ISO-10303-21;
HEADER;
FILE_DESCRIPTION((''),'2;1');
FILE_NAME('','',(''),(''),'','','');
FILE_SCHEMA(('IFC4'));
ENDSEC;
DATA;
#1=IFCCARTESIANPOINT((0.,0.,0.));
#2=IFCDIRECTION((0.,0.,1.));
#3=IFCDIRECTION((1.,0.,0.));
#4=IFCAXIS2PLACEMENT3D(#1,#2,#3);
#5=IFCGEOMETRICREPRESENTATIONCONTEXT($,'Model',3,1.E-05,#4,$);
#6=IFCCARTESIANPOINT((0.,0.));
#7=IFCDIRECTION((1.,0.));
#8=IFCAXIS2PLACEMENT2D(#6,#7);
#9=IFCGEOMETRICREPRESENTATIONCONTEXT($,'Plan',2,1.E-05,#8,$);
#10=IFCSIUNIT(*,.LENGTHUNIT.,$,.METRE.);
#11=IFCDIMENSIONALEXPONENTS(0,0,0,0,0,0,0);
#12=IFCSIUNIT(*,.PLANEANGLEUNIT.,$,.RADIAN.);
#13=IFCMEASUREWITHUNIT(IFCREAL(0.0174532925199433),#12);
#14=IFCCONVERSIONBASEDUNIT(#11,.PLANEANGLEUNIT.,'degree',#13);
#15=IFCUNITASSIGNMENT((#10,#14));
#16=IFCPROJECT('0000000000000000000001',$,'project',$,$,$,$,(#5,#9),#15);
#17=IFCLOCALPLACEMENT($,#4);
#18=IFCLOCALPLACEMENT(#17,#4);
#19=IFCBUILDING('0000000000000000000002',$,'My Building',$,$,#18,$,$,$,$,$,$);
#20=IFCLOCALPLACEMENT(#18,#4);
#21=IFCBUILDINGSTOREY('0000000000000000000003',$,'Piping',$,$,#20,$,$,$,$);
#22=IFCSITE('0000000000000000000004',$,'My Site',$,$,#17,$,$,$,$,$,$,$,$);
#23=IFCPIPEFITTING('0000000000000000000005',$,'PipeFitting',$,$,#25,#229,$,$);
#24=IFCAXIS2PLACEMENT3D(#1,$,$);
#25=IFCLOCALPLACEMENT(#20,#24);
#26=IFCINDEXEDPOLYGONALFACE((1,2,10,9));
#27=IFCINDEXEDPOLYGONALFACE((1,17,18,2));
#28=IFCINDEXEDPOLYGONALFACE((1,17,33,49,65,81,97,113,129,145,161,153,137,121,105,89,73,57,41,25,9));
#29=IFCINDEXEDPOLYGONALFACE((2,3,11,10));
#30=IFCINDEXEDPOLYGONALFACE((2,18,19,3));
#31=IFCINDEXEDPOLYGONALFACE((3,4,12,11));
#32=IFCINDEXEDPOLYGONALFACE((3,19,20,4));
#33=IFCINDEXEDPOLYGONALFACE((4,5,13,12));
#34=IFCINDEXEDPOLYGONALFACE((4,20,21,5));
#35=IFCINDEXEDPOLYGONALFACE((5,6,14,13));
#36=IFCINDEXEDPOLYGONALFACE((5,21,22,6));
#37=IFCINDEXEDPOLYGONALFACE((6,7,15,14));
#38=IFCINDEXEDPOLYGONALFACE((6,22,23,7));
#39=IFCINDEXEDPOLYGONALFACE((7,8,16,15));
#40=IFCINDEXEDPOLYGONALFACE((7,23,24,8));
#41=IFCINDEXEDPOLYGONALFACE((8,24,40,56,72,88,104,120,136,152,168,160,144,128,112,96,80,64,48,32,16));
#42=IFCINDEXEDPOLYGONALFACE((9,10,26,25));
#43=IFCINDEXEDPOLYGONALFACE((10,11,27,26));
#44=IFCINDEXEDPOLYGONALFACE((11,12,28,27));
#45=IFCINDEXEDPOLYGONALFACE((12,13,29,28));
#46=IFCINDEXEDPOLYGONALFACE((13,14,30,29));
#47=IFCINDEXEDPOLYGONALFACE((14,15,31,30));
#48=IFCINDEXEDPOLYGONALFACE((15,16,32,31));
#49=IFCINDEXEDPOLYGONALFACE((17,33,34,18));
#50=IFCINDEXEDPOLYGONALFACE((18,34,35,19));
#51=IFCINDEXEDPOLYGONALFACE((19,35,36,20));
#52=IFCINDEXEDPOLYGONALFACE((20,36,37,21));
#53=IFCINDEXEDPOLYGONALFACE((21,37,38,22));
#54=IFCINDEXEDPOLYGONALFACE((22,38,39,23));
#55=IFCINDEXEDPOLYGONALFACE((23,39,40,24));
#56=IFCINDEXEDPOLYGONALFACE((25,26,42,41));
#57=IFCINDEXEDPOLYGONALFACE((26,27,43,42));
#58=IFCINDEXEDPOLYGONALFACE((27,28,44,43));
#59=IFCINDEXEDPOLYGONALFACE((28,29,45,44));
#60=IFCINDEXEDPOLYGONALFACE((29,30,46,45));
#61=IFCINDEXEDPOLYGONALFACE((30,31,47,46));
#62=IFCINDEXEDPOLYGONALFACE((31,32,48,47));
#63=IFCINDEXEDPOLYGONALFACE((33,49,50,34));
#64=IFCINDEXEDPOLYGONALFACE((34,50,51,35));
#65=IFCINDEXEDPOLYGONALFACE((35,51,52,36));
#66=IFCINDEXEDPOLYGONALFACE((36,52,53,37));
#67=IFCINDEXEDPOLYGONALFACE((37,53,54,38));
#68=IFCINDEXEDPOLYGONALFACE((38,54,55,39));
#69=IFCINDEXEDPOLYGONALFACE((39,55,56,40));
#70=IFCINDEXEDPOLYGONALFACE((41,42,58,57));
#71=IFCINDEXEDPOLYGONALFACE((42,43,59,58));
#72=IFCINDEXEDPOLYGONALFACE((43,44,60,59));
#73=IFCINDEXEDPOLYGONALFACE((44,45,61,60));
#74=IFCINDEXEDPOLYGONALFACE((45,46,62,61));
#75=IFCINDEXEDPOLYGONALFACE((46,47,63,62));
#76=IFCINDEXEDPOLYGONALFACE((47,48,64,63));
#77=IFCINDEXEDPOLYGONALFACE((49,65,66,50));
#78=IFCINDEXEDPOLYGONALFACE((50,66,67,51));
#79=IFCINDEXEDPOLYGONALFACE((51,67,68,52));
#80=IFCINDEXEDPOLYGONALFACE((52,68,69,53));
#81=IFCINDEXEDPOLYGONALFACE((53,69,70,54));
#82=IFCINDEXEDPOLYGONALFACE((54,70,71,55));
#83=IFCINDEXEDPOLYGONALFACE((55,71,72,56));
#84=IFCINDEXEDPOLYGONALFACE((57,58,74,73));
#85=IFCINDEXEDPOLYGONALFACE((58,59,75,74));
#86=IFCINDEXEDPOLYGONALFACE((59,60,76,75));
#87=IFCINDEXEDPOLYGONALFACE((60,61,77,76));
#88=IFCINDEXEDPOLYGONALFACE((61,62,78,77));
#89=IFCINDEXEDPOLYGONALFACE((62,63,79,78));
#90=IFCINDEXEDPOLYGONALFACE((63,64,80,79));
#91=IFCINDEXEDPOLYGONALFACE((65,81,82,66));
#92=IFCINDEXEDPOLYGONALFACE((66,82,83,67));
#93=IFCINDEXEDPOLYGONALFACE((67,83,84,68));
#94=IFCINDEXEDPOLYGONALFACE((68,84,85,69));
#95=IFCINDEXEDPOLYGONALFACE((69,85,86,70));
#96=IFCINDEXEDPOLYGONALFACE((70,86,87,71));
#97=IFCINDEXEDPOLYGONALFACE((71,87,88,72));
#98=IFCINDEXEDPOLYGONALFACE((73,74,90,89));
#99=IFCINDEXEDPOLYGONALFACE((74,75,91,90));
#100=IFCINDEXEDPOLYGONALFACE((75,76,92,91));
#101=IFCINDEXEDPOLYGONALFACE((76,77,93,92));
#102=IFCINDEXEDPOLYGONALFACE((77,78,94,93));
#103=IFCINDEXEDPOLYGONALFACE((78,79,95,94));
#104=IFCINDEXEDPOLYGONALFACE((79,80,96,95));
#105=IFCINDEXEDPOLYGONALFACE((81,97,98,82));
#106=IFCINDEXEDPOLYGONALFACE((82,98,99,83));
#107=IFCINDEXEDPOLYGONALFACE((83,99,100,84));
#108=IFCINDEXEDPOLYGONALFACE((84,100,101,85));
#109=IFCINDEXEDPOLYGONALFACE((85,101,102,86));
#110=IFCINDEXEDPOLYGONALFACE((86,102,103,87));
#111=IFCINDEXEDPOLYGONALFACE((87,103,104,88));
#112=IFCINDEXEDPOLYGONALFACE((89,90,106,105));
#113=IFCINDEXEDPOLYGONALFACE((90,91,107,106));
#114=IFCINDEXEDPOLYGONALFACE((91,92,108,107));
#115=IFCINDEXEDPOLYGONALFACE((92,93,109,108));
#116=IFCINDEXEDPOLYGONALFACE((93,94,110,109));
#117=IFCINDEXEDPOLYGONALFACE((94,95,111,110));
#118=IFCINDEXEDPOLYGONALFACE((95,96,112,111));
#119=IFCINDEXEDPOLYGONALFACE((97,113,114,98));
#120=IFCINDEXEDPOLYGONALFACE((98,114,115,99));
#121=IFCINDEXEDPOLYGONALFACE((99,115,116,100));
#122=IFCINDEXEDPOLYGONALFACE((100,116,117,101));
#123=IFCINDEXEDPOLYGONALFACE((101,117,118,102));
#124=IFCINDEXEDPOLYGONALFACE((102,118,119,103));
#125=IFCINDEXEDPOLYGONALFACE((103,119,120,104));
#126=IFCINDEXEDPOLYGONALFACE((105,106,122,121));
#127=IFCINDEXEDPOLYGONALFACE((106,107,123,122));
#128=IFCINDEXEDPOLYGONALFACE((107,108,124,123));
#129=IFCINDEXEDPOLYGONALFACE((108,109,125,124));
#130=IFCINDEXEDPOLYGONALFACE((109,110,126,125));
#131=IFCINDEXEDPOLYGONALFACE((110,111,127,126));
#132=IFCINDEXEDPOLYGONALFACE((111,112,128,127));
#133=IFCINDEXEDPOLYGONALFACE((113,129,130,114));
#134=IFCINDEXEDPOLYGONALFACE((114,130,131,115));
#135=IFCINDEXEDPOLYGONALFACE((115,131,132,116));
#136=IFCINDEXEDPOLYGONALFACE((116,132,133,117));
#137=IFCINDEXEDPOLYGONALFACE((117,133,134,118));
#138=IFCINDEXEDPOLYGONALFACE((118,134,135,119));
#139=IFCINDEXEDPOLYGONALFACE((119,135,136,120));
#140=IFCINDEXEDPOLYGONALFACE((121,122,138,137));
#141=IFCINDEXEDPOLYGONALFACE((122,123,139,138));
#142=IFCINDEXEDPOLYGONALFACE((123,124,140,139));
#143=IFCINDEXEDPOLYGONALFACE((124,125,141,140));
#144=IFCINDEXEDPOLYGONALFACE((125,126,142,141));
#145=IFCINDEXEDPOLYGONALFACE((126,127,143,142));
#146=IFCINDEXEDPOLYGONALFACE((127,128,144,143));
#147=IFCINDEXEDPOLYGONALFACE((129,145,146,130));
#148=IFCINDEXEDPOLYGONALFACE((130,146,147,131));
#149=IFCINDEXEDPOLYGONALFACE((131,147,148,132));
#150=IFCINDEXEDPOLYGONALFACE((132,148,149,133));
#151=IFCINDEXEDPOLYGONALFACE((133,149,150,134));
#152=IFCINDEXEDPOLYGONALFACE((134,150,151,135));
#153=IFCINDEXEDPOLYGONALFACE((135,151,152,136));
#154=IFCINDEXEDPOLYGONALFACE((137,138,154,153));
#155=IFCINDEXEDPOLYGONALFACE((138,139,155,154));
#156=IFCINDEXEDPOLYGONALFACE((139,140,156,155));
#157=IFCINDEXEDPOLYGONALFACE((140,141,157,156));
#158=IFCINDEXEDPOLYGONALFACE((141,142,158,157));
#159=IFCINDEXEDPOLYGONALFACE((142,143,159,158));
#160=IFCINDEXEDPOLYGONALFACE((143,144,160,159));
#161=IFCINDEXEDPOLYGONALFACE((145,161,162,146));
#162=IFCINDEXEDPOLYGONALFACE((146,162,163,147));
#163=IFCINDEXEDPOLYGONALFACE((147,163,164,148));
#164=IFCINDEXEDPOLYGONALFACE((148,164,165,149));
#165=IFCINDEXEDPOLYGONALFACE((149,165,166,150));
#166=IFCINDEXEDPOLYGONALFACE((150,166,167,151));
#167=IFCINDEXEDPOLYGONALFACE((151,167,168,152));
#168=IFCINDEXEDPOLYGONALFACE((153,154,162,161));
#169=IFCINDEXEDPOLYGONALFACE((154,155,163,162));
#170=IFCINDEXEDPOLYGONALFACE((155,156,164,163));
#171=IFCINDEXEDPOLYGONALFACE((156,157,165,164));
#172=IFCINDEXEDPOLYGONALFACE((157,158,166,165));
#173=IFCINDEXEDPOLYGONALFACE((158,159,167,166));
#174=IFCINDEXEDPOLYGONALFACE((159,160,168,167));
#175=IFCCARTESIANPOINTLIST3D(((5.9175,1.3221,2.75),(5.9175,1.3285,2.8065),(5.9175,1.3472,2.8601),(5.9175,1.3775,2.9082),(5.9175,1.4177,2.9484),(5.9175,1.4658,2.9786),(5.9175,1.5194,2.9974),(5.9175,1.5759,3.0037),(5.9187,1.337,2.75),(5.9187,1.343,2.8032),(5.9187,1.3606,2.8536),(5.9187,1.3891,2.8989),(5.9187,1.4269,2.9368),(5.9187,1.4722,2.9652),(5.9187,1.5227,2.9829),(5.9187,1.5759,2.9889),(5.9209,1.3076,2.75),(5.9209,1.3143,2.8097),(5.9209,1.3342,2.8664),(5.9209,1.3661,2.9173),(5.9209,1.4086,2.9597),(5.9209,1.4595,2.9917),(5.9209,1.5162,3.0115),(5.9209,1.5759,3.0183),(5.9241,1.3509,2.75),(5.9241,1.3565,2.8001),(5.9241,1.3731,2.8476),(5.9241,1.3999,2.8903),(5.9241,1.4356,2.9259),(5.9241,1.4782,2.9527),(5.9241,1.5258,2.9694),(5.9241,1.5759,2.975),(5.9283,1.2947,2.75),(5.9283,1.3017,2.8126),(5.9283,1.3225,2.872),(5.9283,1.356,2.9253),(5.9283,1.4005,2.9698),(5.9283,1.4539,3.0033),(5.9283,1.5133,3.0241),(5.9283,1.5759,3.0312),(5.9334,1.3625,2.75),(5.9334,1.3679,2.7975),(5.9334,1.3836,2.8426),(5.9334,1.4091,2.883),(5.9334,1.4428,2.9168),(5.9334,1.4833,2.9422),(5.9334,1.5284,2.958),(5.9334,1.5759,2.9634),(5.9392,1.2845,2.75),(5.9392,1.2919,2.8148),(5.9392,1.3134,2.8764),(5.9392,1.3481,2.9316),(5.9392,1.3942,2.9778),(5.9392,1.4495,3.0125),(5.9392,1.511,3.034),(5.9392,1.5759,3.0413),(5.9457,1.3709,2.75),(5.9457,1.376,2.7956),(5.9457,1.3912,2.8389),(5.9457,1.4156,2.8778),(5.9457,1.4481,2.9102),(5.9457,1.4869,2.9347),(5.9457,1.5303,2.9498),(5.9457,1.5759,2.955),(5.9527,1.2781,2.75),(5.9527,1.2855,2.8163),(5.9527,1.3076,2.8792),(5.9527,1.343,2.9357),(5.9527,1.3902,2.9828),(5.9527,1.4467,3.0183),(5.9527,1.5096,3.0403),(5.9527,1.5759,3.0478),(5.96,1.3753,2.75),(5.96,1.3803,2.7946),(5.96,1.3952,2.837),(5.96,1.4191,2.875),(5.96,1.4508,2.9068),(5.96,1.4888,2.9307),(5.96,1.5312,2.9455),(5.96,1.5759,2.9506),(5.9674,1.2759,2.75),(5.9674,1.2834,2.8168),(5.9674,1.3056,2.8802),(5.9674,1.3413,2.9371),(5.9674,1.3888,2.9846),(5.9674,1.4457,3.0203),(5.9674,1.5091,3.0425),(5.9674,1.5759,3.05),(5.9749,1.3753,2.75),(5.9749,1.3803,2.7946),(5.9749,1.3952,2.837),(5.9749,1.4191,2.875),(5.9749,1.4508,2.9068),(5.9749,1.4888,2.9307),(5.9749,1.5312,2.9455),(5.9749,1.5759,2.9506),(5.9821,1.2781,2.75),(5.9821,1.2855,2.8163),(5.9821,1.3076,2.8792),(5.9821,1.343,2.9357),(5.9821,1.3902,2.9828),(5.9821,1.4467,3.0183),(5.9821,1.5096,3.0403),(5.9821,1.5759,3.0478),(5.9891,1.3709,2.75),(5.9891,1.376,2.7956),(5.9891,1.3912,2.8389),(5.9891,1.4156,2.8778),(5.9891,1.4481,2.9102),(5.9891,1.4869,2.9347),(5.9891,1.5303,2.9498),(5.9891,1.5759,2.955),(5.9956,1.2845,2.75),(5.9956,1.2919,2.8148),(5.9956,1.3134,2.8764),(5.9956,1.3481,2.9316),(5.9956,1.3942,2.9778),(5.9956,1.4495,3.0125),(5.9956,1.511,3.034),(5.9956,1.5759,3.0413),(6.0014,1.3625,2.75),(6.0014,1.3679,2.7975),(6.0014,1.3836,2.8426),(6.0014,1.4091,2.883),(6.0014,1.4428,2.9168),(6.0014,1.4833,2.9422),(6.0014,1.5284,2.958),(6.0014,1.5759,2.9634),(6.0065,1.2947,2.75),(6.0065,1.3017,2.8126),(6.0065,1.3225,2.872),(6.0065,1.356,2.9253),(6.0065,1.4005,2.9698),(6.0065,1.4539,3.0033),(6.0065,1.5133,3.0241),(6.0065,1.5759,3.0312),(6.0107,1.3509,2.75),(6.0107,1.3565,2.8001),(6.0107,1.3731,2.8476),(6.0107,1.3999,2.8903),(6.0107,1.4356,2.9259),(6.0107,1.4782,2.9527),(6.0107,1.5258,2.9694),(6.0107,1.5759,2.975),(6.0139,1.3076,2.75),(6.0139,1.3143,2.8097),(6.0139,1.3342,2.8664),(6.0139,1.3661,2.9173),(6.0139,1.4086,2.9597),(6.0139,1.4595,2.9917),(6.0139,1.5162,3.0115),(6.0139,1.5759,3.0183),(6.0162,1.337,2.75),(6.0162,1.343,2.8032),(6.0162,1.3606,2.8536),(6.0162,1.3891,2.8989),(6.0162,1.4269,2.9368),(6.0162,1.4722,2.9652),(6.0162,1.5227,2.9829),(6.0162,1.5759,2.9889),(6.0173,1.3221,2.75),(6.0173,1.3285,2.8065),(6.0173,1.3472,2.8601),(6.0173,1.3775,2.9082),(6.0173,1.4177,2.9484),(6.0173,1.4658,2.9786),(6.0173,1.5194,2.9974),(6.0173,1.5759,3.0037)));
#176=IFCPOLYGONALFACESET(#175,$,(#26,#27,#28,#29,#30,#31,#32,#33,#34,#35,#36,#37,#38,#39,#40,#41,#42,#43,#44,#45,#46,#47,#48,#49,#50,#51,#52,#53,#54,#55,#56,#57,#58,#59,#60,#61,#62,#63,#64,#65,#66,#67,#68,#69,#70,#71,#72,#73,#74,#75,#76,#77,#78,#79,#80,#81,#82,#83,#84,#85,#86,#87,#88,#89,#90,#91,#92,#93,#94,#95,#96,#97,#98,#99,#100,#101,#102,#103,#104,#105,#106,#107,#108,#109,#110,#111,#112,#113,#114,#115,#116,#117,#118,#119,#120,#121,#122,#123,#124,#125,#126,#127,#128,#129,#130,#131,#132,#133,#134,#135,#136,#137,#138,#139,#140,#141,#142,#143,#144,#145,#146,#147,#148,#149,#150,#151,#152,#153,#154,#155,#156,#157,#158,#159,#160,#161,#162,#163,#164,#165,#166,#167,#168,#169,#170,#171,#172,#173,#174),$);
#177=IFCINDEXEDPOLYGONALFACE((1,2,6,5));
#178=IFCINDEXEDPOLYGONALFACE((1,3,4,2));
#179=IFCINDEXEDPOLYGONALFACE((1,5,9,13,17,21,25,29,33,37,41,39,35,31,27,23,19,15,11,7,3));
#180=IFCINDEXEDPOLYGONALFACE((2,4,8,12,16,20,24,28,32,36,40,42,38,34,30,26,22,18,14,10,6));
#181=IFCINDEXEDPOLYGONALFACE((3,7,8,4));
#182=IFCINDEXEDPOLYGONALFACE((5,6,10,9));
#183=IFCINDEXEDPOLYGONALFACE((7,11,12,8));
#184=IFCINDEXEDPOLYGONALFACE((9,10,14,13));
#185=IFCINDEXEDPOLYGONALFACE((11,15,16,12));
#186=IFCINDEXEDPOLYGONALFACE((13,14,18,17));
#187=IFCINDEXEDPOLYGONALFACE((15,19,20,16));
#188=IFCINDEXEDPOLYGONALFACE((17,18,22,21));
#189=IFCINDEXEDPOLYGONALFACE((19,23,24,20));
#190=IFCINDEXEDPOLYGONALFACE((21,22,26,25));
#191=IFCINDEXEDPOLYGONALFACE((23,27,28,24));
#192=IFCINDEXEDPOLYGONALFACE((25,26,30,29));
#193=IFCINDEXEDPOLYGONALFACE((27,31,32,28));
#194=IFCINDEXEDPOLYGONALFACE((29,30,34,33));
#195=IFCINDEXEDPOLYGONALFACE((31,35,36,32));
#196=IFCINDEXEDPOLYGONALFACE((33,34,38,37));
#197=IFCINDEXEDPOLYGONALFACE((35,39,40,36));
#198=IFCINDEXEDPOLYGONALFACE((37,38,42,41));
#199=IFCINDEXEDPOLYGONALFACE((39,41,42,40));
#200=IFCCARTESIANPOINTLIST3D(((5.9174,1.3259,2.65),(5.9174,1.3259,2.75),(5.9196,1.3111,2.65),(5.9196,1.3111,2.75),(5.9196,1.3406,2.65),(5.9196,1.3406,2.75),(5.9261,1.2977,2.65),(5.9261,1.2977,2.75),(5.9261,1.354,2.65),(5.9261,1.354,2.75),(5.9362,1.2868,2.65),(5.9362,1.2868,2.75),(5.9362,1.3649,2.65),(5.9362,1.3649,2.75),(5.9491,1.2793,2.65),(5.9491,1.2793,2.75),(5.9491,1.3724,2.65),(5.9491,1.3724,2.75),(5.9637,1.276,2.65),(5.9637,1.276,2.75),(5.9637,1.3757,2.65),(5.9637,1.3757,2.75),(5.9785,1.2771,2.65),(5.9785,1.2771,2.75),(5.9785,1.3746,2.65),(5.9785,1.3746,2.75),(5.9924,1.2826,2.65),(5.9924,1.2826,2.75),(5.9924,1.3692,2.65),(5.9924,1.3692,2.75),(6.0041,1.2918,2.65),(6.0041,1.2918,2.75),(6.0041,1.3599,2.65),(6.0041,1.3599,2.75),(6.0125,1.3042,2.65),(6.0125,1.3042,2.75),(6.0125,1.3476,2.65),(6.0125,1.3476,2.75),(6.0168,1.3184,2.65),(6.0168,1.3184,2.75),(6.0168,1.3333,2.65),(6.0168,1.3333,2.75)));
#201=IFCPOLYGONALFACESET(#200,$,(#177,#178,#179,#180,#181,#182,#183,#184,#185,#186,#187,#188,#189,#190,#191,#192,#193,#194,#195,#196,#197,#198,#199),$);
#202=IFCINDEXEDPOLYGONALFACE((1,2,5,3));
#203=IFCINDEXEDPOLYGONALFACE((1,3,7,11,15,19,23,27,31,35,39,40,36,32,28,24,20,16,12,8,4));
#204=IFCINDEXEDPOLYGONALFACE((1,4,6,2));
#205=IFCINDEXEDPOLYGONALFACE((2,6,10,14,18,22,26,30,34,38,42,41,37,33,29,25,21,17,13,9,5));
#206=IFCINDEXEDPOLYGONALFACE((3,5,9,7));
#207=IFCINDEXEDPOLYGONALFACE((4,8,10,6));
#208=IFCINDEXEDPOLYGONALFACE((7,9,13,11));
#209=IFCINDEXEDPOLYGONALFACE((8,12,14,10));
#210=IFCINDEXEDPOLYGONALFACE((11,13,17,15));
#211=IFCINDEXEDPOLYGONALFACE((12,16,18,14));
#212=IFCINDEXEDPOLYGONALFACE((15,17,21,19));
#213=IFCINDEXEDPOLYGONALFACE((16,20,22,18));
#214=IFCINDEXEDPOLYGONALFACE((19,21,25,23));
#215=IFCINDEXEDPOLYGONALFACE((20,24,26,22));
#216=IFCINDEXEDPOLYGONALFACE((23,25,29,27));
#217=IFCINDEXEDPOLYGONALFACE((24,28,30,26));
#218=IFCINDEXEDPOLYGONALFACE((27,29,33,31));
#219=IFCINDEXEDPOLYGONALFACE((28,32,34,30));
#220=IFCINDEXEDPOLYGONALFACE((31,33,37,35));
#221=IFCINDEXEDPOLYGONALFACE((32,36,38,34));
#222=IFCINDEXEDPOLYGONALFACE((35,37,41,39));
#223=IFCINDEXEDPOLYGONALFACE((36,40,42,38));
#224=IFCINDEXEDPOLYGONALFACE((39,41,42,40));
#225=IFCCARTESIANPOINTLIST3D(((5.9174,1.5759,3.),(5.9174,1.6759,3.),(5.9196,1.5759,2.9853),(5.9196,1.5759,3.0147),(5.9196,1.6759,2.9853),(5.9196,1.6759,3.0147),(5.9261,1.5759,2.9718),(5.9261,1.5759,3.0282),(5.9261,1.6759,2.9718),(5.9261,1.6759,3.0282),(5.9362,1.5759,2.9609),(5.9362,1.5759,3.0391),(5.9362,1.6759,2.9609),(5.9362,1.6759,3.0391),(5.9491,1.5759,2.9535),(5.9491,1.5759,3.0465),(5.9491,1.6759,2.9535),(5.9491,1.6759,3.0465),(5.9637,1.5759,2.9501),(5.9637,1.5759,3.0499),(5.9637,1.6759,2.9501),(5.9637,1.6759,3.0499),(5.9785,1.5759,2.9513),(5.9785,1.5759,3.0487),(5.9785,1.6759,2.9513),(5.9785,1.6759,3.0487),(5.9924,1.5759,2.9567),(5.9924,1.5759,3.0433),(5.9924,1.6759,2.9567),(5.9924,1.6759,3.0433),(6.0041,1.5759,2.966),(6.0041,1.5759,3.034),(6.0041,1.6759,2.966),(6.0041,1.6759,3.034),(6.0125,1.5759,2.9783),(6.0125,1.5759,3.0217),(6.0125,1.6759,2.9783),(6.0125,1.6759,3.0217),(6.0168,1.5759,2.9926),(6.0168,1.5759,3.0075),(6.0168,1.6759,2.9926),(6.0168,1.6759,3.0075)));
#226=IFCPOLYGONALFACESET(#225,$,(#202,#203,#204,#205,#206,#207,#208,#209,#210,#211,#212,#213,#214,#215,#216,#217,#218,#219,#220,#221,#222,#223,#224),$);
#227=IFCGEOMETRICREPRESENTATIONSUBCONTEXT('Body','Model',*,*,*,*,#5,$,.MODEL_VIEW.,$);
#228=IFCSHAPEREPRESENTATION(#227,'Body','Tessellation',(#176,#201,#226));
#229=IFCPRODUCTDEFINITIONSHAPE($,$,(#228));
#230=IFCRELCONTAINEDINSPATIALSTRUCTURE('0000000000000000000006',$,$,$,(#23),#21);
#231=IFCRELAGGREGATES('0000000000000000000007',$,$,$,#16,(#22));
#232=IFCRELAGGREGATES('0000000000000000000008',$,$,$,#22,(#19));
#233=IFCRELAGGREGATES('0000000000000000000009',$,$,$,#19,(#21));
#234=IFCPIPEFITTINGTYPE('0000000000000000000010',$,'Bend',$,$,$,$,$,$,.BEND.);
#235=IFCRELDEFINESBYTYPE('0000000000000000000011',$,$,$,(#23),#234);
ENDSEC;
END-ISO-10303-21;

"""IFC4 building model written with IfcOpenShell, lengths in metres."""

from ifc_helpers import new_model, entity, si_unit, converted_unit, frame, origin_with_axes, origin_2d_with_axis, place, context, subcontext, project, spatial, circle, extrude, source, transform, mapped, type_object, type_shapes, element, save


model = new_model("IFC4")

# Units and contexts
model_context = context("Model", 3, precision=1e-05, world=origin_with_axes())
plan_context = context("Plan", 2, precision=1e-05, world=origin_2d_with_axis())
body_context = subcontext(model_context, "Body", "Model", "MODEL_VIEW")
ifc_project = project(units=[si_unit("LENGTHUNIT", "METRE"), converted_unit("PLANEANGLEUNIT", "degree", entity("IfcReal", 0.0174532925199433), si_unit("PLANEANGLEUNIT", "RADIAN"), dimensions=[0, 0, 0, 0, 0, 0, 0])], contexts=[model_context, plan_context])

# Site, building, storey
site_placement = place(None, origin_with_axes())
site = spatial("IfcSite", under=ifc_project, at=site_placement, Name="My Site")
building_placement = place(site_placement, origin_with_axes())
building = spatial("IfcBuilding", under=site, at=building_placement, Name="My Building")
storey_placement = place(building_placement, origin_with_axes())
storey = spatial("IfcBuildingStorey", under=building, at=storey_placement, Name="Piping")

# Pipe fitting
pipe_fitting_type = type_object("IfcPipeFittingType", Name="Bend", PredefinedType="BEND")
shared_shape = source(origin_with_axes(), body_context, "Body", "SolidModel", [
    entity("IfcSweptDiskSolid", entity("IfcIndexedPolyCurve", entity("IfcCartesianPointList3D", [[0.0, 0.0, -0.1], [0.0, 0.0732, -0.2768], [0.0, 0.25, -0.35]]), [entity("IfcArcIndex", [1, 2, 3])]), 0.05),
    extrude(circle(Radius=0.05), origin_with_axes(), (0.0, 0.0, -1.0), 0.1),
    extrude(circle(Radius=0.05), frame((0.0, 0.25, -0.35), z_axis=(0.0, 1.0, 0.0), x_axis=(1.0, 0.0, 0.0)), (0.0, 0.0, 1.0), 0.1),
])
type_shapes(pipe_fitting_type, [shared_shape])
for number, where, z_axis, x_axis, name in (
    (1, (5.9674, 1.3259, 2.65), (0.0, 0.0, -1.0), (-1.0, 0.0, 0.0), "PipeFitting"),
):
    element("IfcPipeFitting", number, at=place(storey_placement, frame(where, z_axis=z_axis, x_axis=x_axis)), inside=storey, type_object=pipe_fitting_type, Name=name, context=body_context, shape_type="MappedRepresentation", body=[
        mapped(shared_shape, transform((0.0, 0.0, 0.0), x_axis=(1.0, 0.0, 0.0), y_axis=(0.0, 1.0, 0.0), z_axis=(0.0, 0.0, 1.0), scale=1.0)),
    ])

save(model, "model.ifc")
